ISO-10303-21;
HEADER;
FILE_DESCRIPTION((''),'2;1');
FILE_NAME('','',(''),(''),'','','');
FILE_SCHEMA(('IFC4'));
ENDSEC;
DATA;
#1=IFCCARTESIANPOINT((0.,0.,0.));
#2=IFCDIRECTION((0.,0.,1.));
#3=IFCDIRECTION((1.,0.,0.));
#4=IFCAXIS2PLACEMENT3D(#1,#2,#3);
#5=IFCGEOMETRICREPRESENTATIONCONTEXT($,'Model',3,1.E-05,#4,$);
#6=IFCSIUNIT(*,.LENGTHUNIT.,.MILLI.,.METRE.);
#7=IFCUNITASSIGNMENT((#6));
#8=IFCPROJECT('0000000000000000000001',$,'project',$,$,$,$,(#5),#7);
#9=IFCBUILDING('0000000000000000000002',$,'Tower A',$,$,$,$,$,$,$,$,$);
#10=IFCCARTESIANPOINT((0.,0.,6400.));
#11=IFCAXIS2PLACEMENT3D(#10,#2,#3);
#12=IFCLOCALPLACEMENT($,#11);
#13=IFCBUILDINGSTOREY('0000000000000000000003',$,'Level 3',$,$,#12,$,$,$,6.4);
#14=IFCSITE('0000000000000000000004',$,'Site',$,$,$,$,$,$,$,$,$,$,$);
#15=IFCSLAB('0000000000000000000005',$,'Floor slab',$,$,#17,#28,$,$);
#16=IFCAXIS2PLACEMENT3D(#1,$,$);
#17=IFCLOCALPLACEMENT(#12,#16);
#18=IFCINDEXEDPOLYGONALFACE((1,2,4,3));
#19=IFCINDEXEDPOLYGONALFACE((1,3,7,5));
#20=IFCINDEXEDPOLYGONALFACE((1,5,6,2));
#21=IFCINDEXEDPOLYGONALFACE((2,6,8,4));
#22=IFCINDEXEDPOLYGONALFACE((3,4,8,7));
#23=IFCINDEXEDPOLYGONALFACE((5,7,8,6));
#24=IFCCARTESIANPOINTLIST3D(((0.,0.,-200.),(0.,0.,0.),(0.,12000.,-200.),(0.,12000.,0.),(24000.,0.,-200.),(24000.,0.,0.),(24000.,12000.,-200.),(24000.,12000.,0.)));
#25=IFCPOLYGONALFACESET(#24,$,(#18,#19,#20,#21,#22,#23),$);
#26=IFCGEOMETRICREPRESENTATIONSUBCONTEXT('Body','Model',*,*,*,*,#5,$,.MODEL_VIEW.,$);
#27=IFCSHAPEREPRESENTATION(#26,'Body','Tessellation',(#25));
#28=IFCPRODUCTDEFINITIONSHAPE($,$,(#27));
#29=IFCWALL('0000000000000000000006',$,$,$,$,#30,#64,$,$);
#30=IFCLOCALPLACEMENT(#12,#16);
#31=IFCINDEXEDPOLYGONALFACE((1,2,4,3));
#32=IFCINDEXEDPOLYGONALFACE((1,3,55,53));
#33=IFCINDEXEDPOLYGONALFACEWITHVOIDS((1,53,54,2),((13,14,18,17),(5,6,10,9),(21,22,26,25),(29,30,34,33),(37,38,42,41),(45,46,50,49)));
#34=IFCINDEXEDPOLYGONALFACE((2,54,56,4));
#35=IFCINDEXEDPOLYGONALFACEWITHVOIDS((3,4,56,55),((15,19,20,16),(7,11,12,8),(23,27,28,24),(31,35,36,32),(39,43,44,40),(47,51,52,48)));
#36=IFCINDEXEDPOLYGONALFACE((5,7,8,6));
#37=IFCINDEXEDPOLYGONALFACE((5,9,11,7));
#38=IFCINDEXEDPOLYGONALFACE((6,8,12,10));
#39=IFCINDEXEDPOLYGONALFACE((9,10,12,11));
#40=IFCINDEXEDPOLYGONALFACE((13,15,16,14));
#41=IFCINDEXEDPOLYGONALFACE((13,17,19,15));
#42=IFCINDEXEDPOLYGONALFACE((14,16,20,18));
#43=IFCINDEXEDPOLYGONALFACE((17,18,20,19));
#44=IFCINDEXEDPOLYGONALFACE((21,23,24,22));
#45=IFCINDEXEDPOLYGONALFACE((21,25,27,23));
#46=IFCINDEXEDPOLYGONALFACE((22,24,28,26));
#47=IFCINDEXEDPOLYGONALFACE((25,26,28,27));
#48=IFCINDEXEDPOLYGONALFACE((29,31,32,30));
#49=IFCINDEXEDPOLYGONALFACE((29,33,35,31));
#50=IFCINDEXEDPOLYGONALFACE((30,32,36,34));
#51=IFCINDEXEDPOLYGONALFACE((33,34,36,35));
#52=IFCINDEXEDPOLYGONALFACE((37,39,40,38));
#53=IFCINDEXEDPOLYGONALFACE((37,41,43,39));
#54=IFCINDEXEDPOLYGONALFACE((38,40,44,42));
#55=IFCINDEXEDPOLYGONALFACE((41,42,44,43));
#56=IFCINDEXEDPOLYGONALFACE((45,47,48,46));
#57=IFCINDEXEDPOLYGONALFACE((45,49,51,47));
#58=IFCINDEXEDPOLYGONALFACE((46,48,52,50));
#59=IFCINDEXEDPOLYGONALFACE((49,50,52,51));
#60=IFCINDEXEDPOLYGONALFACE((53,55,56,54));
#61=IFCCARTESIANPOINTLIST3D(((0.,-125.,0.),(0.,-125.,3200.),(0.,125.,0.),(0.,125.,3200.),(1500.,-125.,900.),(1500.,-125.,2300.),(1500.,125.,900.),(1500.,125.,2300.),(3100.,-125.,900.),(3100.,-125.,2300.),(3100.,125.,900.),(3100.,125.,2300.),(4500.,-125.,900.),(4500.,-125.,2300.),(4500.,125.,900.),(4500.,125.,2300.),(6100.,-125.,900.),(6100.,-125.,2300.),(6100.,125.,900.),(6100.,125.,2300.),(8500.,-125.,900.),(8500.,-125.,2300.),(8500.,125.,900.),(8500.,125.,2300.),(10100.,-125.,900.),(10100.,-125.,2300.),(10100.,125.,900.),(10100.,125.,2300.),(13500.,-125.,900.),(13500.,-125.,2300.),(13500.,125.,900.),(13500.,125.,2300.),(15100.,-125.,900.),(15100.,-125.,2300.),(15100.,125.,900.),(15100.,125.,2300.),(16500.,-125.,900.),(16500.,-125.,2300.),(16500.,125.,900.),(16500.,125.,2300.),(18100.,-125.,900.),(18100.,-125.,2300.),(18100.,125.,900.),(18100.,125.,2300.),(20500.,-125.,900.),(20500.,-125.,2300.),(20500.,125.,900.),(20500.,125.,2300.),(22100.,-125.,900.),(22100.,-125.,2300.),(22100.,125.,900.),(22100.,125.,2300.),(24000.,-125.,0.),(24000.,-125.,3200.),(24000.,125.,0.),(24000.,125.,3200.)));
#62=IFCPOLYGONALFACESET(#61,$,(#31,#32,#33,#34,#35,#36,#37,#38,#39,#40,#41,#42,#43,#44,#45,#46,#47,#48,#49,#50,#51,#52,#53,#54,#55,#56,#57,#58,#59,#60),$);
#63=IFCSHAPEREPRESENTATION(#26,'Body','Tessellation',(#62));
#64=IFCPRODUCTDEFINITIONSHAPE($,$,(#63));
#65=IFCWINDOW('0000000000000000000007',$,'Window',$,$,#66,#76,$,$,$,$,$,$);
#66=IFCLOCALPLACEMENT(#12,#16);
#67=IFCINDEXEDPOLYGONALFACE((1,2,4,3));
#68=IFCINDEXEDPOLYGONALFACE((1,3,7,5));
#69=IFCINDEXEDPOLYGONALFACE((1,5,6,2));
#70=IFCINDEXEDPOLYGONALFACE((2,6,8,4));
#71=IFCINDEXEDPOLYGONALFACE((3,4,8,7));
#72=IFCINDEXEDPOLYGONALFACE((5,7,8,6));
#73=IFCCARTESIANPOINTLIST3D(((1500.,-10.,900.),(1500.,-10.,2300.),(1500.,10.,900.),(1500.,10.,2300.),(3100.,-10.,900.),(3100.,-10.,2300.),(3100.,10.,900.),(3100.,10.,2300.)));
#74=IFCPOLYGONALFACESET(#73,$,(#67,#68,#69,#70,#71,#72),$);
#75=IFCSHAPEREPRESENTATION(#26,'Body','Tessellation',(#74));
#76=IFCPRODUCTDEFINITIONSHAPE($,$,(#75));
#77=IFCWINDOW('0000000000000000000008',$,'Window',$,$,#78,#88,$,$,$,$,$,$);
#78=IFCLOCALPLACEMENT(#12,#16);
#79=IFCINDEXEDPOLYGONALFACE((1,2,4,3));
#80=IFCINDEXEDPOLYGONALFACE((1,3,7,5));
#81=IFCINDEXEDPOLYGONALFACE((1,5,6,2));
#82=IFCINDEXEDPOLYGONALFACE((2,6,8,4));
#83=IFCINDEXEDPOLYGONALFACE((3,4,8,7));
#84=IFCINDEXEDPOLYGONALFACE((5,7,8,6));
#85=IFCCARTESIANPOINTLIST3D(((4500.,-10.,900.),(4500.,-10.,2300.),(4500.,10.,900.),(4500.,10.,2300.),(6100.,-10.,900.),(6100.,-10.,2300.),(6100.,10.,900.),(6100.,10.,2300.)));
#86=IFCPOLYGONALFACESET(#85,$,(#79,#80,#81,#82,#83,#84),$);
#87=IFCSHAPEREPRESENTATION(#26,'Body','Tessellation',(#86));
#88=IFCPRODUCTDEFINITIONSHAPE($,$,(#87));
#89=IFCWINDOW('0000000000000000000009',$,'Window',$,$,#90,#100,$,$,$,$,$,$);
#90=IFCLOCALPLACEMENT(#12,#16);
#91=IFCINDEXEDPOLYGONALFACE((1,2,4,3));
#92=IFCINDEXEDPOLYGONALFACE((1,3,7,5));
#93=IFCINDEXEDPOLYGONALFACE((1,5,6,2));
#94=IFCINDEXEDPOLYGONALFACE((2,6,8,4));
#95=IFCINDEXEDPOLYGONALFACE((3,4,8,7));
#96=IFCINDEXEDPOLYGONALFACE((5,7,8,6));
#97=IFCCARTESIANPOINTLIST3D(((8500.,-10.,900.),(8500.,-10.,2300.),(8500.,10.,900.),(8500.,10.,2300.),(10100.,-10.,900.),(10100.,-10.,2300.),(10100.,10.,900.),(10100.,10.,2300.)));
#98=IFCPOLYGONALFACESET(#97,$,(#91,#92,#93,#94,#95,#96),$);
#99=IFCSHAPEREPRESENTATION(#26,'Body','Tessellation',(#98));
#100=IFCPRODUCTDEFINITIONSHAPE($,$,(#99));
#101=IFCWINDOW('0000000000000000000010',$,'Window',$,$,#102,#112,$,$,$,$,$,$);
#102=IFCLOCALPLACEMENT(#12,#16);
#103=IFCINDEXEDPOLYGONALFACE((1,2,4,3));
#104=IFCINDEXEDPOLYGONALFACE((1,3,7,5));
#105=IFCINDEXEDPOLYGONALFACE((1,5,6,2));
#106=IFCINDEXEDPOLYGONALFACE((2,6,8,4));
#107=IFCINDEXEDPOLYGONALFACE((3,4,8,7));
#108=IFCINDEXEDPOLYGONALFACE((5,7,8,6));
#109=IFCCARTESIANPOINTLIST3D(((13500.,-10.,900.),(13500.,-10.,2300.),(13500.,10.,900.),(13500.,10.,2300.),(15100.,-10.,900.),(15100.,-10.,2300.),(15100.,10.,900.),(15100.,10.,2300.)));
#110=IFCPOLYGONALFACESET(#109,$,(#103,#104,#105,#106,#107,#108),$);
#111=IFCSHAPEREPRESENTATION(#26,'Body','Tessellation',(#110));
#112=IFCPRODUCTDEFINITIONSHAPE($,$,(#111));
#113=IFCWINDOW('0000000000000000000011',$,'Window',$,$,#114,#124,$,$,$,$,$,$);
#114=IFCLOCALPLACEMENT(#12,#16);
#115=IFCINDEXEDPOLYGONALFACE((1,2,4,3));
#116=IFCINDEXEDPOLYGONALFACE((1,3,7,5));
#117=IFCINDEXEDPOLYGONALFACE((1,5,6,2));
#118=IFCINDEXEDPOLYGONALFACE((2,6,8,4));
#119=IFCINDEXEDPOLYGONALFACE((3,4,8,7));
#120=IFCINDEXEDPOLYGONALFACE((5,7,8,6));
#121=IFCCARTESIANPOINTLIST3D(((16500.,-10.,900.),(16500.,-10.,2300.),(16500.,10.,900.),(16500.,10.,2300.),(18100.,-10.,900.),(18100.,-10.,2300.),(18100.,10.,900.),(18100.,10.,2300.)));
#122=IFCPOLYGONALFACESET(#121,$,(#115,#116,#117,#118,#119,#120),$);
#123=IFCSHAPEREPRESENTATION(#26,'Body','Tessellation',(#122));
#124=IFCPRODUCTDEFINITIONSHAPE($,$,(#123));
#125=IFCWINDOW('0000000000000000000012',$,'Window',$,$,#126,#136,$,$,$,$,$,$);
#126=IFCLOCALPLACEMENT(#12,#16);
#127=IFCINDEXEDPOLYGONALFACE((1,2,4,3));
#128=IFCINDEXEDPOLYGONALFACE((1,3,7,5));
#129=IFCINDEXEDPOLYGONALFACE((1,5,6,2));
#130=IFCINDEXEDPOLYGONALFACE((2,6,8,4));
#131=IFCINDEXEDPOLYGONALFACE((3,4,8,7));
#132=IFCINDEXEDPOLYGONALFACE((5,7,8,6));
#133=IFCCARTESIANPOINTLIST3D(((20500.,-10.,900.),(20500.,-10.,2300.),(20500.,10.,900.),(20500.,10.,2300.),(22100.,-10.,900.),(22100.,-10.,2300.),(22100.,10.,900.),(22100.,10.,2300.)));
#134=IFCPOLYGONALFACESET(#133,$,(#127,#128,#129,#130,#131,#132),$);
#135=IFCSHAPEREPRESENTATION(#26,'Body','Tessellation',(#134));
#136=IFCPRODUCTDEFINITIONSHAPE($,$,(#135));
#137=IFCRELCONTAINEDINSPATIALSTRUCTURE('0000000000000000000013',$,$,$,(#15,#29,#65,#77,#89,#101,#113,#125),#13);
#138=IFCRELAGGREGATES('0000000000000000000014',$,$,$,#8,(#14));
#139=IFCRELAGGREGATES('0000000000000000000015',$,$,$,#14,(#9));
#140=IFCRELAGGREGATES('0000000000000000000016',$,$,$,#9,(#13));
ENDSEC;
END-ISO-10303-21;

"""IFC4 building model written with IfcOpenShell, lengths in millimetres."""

from ifc_helpers import new_model, si_unit, frame, origin_with_axes, place, context, subcontext, project, spatial, indexed_curve, outline, extrude, element, fill, save


model = new_model("IFC4")

# Units and contexts
model_context = context("Model", 3, precision=1e-05, world=origin_with_axes())
body_context = subcontext(model_context, "Body", "Model", "MODEL_VIEW")
ifc_project = project(units=[si_unit("LENGTHUNIT", "METRE", prefix="MILLI")], contexts=[model_context])

# Site, building, storey
site = spatial("IfcSite", under=ifc_project, Name="Site")
building = spatial("IfcBuilding", under=site, Name="Tower A")
storey_placement = place(None, frame((0.0, 0.0, 6400.0), z_axis=(0.0, 0.0, 1.0), x_axis=(1.0, 0.0, 0.0)))
storey = spatial("IfcBuildingStorey", under=building, at=storey_placement, Name="Level 3", Elevation=6.4)

# Slab
slab_placement = place(storey_placement, frame((0.0, 0.0, -200.0), z_axis=(0.0, 0.0, 1.0), x_axis=(1.0, 0.0, 0.0)))
element("IfcSlab", 1, at=slab_placement, inside=storey, Name="Floor slab", context=body_context, shape_type="SweptSolid", body=[
    extrude(outline(indexed_curve([(0.0, 0.0), (24000.0, 0.0), (24000.0, 12000.0), (0.0, 12000.0)])), None, (0.0, 0.0, 1.0), 200.0),
])

# Wall, openings, windows
wall_1_placement = place(storey_placement, frame((0.0, -125.0, 0.0), z_axis=(0.0, 0.0, 1.0), x_axis=(1.0, 0.0, 0.0)))
wall_1 = element("IfcWall", 2, at=wall_1_placement, inside=storey, context=body_context, shape_type="SweptSolid", body=[
    extrude(outline(indexed_curve([(0.0, 0.0), (0.0, 250.0), (24000.0, 250.0), (24000.0, 0.0), (0.0, 0.0)], self_intersect=False)), origin_with_axes(), (0.0, 0.0, 1.0), 3200.0),
])
opening_1_placement = place(wall_1_placement, frame((1500.0, 0.0, 900.0), z_axis=(0.0, 0.0, 1.0), x_axis=(1.0, 0.0, 0.0)))
opening_1 = element("IfcOpeningElement", 3, at=opening_1_placement, cuts=wall_1, context=body_context, shape_type="SweptSolid", body=[
    extrude(outline(indexed_curve([(0.0, 0.0), (0.0, 250.0), (1600.0, 250.0), (1600.0, 0.0), (0.0, 0.0)], self_intersect=False)), origin_with_axes(), (0.0, 0.0, 1.0), 1400.0),
])
opening_2_placement = place(wall_1_placement, frame((4500.0, 0.0, 900.0), z_axis=(0.0, 0.0, 1.0), x_axis=(1.0, 0.0, 0.0)))
opening_2 = element("IfcOpeningElement", 4, at=opening_2_placement, cuts=wall_1, context=body_context, shape_type="SweptSolid", body=[
    extrude(outline(indexed_curve([(0.0, 0.0), (0.0, 250.0), (1600.0, 250.0), (1600.0, 0.0), (0.0, 0.0)], self_intersect=False)), origin_with_axes(), (0.0, 0.0, 1.0), 1400.0),
])
opening_3_placement = place(wall_1_placement, frame((8500.0, 0.0, 900.0), z_axis=(0.0, 0.0, 1.0), x_axis=(1.0, 0.0, 0.0)))
opening_3 = element("IfcOpeningElement", 5, at=opening_3_placement, cuts=wall_1, context=body_context, shape_type="SweptSolid", body=[
    extrude(outline(indexed_curve([(0.0, 0.0), (0.0, 250.0), (1600.0, 250.0), (1600.0, 0.0), (0.0, 0.0)], self_intersect=False)), origin_with_axes(), (0.0, 0.0, 1.0), 1400.0),
])
opening_4_placement = place(wall_1_placement, frame((13500.0, 0.0, 900.0), z_axis=(0.0, 0.0, 1.0), x_axis=(1.0, 0.0, 0.0)))
opening_4 = element("IfcOpeningElement", 6, at=opening_4_placement, cuts=wall_1, context=body_context, shape_type="SweptSolid", body=[
    extrude(outline(indexed_curve([(0.0, 0.0), (0.0, 250.0), (1600.0, 250.0), (1600.0, 0.0), (0.0, 0.0)], self_intersect=False)), origin_with_axes(), (0.0, 0.0, 1.0), 1400.0),
])
opening_5_placement = place(wall_1_placement, frame((16500.0, 0.0, 900.0), z_axis=(0.0, 0.0, 1.0), x_axis=(1.0, 0.0, 0.0)))
opening_5 = element("IfcOpeningElement", 7, at=opening_5_placement, cuts=wall_1, context=body_context, shape_type="SweptSolid", body=[
    extrude(outline(indexed_curve([(0.0, 0.0), (0.0, 250.0), (1600.0, 250.0), (1600.0, 0.0), (0.0, 0.0)], self_intersect=False)), origin_with_axes(), (0.0, 0.0, 1.0), 1400.0),
])
opening_6_placement = place(wall_1_placement, frame((20500.0, 0.0, 900.0), z_axis=(0.0, 0.0, 1.0), x_axis=(1.0, 0.0, 0.0)))
opening_6 = element("IfcOpeningElement", 8, at=opening_6_placement, cuts=wall_1, context=body_context, shape_type="SweptSolid", body=[
    extrude(outline(indexed_curve([(0.0, 0.0), (0.0, 250.0), (1600.0, 250.0), (1600.0, 0.0), (0.0, 0.0)], self_intersect=False)), origin_with_axes(), (0.0, 0.0, 1.0), 1400.0),
])
window_1_placement = place(storey_placement, frame((1500.0, -10.0, 900.0), z_axis=(0.0, 0.0, 1.0), x_axis=(1.0, 0.0, 0.0)))
window_1 = element("IfcWindow", 9, at=window_1_placement, inside=storey, Name="Window", context=body_context, shape_type="SweptSolid", body=[
    extrude(outline(indexed_curve([(0.0, 0.0), (0.0, 20.0), (1600.0, 20.0), (1600.0, 0.0), (0.0, 0.0)], self_intersect=False)), origin_with_axes(), (0.0, 0.0, 1.0), 1400.0),
])
fill(opening_1, window_1)
window_2_placement = place(storey_placement, frame((4500.0, -10.0, 900.0), z_axis=(0.0, 0.0, 1.0), x_axis=(1.0, 0.0, 0.0)))
window_2 = element("IfcWindow", 10, at=window_2_placement, inside=storey, Name="Window", context=body_context, shape_type="SweptSolid", body=[
    extrude(outline(indexed_curve([(0.0, 0.0), (0.0, 20.0), (1600.0, 20.0), (1600.0, 0.0), (0.0, 0.0)], self_intersect=False)), origin_with_axes(), (0.0, 0.0, 1.0), 1400.0),
])
fill(opening_2, window_2)
window_3_placement = place(storey_placement, frame((8500.0, -10.0, 900.0), z_axis=(0.0, 0.0, 1.0), x_axis=(1.0, 0.0, 0.0)))
window_3 = element("IfcWindow", 11, at=window_3_placement, inside=storey, Name="Window", context=body_context, shape_type="SweptSolid", body=[
    extrude(outline(indexed_curve([(0.0, 0.0), (0.0, 20.0), (1600.0, 20.0), (1600.0, 0.0), (0.0, 0.0)], self_intersect=False)), origin_with_axes(), (0.0, 0.0, 1.0), 1400.0),
])
fill(opening_3, window_3)
window_4_placement = place(storey_placement, frame((13500.0, -10.0, 900.0), z_axis=(0.0, 0.0, 1.0), x_axis=(1.0, 0.0, 0.0)))
window_4 = element("IfcWindow", 12, at=window_4_placement, inside=storey, Name="Window", context=body_context, shape_type="SweptSolid", body=[
    extrude(outline(indexed_curve([(0.0, 0.0), (0.0, 20.0), (1600.0, 20.0), (1600.0, 0.0), (0.0, 0.0)], self_intersect=False)), origin_with_axes(), (0.0, 0.0, 1.0), 1400.0),
])
fill(opening_4, window_4)
window_5_placement = place(storey_placement, frame((16500.0, -10.0, 900.0), z_axis=(0.0, 0.0, 1.0), x_axis=(1.0, 0.0, 0.0)))
window_5 = element("IfcWindow", 13, at=window_5_placement, inside=storey, Name="Window", context=body_context, shape_type="SweptSolid", body=[
    extrude(outline(indexed_curve([(0.0, 0.0), (0.0, 20.0), (1600.0, 20.0), (1600.0, 0.0), (0.0, 0.0)], self_intersect=False)), origin_with_axes(), (0.0, 0.0, 1.0), 1400.0),
])
fill(opening_5, window_5)
window_6_placement = place(storey_placement, frame((20500.0, -10.0, 900.0), z_axis=(0.0, 0.0, 1.0), x_axis=(1.0, 0.0, 0.0)))
window_6 = element("IfcWindow", 14, at=window_6_placement, inside=storey, Name="Window", context=body_context, shape_type="SweptSolid", body=[
    extrude(outline(indexed_curve([(0.0, 0.0), (0.0, 20.0), (1600.0, 20.0), (1600.0, 0.0), (0.0, 0.0)], self_intersect=False)), origin_with_axes(), (0.0, 0.0, 1.0), 1400.0),
])
fill(opening_6, window_6)

save(model, "model.ifc")
